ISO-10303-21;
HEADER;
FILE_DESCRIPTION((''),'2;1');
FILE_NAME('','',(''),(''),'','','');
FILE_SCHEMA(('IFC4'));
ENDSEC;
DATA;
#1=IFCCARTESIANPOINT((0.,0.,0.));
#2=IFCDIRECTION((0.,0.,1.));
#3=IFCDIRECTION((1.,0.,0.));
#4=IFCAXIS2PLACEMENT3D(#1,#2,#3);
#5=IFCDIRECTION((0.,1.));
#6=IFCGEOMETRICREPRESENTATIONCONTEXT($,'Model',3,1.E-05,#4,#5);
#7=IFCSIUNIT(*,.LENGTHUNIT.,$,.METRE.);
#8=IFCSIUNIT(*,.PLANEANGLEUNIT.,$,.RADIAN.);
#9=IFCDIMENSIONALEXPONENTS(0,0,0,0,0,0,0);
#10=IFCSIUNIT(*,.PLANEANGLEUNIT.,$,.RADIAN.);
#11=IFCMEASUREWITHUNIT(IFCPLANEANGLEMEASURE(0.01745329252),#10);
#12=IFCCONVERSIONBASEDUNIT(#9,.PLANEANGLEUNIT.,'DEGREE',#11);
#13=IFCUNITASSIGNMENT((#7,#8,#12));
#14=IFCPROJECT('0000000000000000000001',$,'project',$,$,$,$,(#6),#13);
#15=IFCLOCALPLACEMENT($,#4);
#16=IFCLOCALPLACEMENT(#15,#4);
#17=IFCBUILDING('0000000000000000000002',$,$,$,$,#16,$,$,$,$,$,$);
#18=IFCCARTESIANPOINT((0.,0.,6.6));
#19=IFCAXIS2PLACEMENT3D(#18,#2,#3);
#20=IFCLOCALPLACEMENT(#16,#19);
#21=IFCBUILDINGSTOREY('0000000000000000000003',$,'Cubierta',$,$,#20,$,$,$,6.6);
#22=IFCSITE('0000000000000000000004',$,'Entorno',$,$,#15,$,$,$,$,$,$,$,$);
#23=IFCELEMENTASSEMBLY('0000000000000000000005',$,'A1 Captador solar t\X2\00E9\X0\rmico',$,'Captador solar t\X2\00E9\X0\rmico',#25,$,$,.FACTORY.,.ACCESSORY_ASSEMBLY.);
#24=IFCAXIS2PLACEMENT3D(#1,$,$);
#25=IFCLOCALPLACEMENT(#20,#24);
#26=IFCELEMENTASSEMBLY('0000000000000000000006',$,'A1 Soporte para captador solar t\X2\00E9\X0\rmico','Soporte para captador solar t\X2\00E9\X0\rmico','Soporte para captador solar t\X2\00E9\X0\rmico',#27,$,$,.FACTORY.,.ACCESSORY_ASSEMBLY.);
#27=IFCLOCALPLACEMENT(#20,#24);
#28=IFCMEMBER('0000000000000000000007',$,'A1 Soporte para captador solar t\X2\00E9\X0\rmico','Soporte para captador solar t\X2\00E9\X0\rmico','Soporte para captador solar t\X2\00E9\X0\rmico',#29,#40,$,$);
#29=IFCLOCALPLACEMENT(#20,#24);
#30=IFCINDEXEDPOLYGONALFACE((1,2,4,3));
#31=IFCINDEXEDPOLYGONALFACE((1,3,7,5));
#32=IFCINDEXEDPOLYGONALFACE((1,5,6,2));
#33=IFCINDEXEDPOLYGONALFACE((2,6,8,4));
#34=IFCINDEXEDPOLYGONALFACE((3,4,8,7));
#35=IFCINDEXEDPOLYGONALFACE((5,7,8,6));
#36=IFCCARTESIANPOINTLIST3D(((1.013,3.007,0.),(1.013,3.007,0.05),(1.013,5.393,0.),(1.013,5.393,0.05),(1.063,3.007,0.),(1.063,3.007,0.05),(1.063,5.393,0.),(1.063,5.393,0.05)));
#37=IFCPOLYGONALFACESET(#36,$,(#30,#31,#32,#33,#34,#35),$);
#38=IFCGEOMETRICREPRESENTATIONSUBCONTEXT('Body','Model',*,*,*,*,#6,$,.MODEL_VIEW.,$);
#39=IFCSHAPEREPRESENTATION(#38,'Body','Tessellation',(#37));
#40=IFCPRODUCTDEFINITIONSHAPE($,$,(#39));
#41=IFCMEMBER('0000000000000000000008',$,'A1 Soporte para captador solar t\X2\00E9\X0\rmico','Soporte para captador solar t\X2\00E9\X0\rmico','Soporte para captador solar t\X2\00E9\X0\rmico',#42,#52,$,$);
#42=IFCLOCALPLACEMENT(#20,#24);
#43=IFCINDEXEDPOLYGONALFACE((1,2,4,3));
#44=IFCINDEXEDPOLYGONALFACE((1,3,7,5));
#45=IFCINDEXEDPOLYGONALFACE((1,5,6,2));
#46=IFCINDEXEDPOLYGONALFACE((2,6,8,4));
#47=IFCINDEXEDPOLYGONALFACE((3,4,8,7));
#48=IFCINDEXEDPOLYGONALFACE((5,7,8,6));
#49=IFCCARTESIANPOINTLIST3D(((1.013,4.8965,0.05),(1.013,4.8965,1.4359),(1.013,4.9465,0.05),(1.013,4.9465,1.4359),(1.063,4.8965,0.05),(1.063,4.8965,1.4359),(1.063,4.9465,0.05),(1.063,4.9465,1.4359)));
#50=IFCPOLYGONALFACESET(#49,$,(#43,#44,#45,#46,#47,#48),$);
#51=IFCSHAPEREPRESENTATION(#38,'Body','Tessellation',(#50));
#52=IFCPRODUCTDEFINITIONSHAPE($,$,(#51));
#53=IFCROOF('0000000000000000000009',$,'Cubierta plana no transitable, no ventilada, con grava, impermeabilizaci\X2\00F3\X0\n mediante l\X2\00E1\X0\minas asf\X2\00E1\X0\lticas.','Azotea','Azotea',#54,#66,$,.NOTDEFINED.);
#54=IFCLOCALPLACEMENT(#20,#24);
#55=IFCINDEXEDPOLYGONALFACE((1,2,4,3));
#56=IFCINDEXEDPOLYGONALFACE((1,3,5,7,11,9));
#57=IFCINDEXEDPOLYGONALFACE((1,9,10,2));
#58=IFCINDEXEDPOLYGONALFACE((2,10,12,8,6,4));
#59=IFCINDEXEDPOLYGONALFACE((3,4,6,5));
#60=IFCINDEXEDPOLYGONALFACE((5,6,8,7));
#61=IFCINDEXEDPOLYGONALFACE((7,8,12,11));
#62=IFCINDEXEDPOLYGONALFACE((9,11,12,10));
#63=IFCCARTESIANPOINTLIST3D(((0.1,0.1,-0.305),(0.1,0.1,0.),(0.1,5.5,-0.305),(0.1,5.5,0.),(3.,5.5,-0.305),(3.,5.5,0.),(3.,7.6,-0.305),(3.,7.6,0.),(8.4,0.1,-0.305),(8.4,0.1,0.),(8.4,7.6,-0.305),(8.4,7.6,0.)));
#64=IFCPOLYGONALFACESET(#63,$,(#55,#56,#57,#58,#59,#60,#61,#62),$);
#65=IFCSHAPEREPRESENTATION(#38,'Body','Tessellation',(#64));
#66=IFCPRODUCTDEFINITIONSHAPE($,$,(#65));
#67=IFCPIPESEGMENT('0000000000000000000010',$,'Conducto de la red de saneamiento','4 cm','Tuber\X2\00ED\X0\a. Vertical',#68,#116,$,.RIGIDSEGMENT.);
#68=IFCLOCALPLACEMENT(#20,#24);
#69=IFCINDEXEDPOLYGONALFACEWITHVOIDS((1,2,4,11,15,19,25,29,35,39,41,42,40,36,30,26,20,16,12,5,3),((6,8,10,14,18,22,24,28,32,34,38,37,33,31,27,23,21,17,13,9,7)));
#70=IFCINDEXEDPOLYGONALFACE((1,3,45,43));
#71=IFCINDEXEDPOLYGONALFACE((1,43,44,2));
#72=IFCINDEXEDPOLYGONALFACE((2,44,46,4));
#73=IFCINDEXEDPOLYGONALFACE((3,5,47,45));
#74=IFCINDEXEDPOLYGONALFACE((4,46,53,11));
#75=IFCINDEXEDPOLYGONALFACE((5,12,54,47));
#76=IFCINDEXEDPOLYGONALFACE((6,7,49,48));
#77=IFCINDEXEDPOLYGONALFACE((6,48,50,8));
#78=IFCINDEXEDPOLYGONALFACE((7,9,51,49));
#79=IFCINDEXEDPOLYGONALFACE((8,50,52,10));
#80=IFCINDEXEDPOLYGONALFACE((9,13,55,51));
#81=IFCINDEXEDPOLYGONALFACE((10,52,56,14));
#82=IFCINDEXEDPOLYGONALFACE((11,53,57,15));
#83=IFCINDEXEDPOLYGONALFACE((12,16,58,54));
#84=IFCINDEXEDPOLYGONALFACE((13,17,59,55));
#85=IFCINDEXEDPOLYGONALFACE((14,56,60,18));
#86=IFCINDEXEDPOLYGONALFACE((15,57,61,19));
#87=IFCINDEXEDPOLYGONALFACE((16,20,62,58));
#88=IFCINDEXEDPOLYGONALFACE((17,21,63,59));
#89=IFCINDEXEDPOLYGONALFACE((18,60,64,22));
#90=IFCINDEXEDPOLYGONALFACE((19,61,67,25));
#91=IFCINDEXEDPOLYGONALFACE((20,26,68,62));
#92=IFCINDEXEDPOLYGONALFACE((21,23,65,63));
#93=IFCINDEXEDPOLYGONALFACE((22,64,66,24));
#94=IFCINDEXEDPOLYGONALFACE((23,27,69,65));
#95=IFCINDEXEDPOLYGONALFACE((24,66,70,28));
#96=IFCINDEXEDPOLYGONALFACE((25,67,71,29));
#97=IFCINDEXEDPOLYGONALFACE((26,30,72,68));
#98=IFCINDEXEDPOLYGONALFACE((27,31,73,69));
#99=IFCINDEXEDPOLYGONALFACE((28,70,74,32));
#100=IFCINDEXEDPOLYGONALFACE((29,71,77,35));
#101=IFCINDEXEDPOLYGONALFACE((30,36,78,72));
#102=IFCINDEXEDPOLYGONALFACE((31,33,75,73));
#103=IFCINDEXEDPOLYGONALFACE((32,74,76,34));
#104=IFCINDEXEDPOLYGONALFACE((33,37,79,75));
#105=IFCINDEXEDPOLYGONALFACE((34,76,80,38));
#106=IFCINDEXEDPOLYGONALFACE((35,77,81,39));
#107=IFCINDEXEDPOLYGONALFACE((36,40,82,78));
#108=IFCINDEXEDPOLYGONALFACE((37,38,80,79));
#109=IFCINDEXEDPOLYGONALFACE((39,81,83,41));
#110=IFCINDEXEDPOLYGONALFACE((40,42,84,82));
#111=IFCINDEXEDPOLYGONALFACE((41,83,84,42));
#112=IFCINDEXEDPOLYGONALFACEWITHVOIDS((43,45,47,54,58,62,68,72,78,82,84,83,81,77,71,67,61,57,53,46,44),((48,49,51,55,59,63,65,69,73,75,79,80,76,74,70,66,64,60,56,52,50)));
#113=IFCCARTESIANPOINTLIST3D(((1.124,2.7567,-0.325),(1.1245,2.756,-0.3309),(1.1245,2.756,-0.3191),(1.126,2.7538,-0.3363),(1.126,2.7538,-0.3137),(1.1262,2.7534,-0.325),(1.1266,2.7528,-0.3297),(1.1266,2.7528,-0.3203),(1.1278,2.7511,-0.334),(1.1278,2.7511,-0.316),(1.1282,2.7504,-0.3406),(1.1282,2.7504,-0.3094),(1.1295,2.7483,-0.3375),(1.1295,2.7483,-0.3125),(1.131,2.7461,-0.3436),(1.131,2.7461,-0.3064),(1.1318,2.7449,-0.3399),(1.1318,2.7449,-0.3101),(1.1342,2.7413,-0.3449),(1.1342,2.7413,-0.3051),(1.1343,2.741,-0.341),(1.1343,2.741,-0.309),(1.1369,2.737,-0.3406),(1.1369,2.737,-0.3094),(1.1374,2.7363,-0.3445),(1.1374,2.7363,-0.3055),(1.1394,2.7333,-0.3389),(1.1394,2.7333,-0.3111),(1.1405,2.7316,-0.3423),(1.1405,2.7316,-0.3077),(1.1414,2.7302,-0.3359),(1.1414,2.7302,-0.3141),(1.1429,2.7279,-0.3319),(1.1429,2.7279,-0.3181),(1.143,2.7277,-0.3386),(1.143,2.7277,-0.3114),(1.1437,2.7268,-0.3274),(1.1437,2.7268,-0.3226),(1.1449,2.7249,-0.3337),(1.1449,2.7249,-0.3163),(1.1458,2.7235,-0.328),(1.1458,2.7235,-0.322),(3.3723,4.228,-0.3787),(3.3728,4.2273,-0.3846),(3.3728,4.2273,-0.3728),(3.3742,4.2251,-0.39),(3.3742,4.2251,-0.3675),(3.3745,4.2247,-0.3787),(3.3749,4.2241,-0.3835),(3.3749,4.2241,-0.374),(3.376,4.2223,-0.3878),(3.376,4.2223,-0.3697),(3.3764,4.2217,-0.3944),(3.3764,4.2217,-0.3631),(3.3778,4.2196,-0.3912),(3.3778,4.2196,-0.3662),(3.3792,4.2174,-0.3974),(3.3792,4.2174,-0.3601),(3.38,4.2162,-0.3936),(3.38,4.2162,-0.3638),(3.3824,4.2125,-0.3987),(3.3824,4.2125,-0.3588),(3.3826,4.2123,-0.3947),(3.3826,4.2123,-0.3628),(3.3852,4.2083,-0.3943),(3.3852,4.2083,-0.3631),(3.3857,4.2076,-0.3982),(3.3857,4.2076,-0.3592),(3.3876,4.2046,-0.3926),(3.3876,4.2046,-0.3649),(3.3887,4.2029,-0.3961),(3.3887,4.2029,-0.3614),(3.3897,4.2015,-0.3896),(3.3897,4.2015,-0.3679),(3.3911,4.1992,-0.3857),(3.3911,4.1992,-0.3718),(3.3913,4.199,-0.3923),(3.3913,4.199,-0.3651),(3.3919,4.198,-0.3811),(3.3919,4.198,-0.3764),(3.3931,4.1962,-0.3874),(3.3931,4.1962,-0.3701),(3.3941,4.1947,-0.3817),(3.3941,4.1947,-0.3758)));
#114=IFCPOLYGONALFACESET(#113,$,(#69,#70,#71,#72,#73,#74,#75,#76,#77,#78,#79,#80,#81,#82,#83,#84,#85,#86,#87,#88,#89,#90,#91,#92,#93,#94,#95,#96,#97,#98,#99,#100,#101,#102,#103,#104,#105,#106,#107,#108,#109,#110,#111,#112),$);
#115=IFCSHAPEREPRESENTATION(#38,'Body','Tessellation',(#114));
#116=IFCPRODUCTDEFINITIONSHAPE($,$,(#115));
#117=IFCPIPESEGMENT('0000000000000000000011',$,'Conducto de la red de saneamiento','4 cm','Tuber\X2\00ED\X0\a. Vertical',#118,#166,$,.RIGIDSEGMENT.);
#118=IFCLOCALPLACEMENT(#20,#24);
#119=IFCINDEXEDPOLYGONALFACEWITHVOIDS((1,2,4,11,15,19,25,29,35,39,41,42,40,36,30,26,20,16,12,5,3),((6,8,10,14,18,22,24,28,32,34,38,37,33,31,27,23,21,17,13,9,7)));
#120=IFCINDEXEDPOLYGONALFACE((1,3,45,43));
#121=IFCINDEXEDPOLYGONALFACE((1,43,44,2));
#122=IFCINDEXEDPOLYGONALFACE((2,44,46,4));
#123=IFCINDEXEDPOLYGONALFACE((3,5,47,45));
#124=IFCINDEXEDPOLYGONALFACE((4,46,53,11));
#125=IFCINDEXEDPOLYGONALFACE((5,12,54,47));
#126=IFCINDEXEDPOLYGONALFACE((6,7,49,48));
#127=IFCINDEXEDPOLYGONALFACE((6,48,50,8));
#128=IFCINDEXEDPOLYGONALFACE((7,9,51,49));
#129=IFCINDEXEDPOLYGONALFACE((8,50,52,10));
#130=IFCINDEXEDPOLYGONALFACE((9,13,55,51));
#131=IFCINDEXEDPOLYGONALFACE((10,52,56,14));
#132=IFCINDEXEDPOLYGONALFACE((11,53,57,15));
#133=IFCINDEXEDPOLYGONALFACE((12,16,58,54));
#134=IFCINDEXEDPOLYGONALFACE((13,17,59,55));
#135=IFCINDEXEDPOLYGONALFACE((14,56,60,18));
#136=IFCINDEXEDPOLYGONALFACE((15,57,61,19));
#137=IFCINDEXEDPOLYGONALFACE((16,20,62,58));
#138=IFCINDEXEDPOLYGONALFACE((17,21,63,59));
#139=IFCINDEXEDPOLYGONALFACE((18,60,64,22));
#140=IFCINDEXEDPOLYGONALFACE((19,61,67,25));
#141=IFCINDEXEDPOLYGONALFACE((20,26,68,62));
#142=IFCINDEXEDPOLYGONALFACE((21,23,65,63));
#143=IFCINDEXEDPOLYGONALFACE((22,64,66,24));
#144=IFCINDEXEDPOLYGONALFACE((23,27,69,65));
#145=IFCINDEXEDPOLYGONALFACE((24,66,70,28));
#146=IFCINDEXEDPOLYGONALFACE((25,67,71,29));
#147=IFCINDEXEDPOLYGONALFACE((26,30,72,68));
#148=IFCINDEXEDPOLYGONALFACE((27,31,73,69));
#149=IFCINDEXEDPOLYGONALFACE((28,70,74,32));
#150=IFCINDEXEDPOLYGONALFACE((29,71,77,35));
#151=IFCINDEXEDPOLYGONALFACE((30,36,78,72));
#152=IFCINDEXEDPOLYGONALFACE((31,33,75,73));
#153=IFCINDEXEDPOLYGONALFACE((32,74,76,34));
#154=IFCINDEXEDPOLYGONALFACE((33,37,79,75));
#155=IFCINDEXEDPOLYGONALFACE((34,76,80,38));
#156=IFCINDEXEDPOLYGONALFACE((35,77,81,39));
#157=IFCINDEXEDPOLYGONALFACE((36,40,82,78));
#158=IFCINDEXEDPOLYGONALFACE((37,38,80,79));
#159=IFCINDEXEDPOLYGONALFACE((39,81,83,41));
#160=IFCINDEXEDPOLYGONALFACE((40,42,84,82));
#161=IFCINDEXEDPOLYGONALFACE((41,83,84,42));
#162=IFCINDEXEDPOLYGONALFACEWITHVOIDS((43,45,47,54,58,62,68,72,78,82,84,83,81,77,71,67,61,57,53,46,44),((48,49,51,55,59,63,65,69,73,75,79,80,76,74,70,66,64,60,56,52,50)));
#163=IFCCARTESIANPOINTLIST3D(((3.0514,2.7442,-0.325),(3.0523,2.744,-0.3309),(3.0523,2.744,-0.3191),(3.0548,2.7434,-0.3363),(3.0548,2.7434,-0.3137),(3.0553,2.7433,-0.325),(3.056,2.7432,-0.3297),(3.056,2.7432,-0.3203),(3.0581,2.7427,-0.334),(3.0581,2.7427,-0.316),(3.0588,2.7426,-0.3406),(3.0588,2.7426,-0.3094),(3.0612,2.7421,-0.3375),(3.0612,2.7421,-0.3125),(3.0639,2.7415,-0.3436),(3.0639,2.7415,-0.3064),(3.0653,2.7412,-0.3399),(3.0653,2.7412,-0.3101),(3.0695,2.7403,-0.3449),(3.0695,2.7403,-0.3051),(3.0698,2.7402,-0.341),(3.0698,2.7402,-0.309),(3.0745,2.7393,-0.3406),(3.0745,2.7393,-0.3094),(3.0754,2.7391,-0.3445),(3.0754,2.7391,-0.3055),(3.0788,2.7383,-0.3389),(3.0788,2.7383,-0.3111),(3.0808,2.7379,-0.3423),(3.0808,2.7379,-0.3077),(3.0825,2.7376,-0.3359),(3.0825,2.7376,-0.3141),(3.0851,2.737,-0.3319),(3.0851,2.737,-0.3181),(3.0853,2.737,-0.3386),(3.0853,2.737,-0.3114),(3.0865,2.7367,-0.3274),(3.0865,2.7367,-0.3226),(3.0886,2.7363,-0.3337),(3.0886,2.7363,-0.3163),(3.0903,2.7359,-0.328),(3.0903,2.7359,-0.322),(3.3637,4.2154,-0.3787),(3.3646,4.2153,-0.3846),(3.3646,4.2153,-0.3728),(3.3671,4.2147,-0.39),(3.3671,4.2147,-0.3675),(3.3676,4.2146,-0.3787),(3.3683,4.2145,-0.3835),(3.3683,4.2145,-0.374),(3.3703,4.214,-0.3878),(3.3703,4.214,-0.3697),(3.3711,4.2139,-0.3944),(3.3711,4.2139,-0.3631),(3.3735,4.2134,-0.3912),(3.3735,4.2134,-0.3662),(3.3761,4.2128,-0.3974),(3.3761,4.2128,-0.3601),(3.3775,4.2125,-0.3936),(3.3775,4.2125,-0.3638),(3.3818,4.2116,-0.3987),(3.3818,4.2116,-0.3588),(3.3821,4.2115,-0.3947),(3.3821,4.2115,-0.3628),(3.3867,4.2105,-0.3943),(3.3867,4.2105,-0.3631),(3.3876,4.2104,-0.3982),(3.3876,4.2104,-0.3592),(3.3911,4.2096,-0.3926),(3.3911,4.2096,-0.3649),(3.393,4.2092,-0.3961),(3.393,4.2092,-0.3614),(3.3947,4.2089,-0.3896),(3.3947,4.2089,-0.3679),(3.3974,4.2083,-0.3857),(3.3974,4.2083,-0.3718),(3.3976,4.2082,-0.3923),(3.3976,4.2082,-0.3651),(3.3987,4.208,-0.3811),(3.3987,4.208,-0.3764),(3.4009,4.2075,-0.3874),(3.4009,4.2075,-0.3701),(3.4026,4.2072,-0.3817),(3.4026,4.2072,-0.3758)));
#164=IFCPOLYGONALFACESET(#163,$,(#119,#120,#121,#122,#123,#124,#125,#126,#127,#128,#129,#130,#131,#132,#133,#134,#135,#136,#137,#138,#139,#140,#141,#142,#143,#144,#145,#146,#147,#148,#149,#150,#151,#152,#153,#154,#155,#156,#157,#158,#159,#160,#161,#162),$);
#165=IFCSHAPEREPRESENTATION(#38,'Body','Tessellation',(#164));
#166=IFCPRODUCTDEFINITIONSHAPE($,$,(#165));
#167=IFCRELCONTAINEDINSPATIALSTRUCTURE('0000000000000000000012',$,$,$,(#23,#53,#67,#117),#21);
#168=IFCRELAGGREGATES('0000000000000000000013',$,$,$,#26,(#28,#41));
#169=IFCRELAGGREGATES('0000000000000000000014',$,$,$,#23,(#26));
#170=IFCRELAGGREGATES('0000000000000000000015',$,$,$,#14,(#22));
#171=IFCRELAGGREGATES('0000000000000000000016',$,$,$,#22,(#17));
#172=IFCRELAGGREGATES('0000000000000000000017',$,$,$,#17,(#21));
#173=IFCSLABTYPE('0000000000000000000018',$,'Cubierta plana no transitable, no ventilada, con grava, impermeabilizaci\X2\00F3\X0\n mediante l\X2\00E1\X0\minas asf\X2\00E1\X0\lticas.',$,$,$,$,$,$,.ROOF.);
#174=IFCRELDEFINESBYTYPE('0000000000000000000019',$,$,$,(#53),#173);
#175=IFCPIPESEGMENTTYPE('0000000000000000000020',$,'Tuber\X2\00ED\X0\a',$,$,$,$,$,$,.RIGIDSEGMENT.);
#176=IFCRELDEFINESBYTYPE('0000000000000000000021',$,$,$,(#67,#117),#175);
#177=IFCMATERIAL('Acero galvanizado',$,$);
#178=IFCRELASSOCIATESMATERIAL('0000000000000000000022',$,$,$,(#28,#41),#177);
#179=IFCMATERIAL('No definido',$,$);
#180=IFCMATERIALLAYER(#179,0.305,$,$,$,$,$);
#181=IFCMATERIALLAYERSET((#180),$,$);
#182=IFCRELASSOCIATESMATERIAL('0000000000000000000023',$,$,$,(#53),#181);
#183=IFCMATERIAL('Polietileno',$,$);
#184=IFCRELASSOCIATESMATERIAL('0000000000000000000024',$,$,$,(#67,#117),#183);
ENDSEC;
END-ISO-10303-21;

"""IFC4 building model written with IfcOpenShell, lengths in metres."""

from ifc_helpers import new_model, entity, si_unit, converted_unit, direction, frame, origin_with_axes, origin_2d_with_axis, place, context, subcontext, project, spatial, polyline, rectangle, hollow_circle, outline, extrude, material, layer, layer_set, layer_usage, type_object, element, aggregate, save


model = new_model("IFC4")

# Units and contexts
model_context = context("Model", 3, precision=1e-05, world=origin_with_axes(), true_north=direction((0.0, 1.0)))
body_context = subcontext(model_context, "Body", "Model", "MODEL_VIEW")
ifc_project = project(units=[si_unit("LENGTHUNIT", "METRE"), si_unit("PLANEANGLEUNIT", "RADIAN"), converted_unit("PLANEANGLEUNIT", "DEGREE", entity("IfcPlaneAngleMeasure", 0.01745329252), si_unit("PLANEANGLEUNIT", "RADIAN"), dimensions=[0, 0, 0, 0, 0, 0, 0])], contexts=[model_context])

# Site, building, storey
site_placement = place(None, origin_with_axes())
site = spatial("IfcSite", under=ifc_project, at=site_placement, Name="Entorno")
building_placement = place(site_placement, origin_with_axes())
building = spatial("IfcBuilding", under=site, at=building_placement)
storey_placement = place(building_placement, frame((0.0, 0.0, 6.6), z_axis=(0.0, 0.0, 1.0), x_axis=(1.0, 0.0, 0.0)))
storey = spatial("IfcBuildingStorey", under=building, at=storey_placement, Name="Cubierta", Elevation=6.6)

# Element assemblies, members
assembly_1_placement = place(storey_placement, frame((1.85, 4.2, 0.0), z_axis=(0.0, 0.0, 1.0), x_axis=(1.0, 0.0, 0.0)))
assembly_1 = element("IfcElementAssembly", 1, at=assembly_1_placement, inside=storey, Name="A1 Captador solar térmico", ObjectType="Captador solar térmico", AssemblyPlace="FACTORY", PredefinedType="ACCESSORY_ASSEMBLY")
assembly_2_placement = place(storey_placement, frame((1.038, 5.393, 0.025), z_axis=(0.0, -1.0, 0.0), x_axis=(1.0, 0.0, 0.0)))
assembly_2 = element("IfcElementAssembly", 2, at=assembly_2_placement, Name="A1 Soporte para captador solar térmico", Description="Soporte para captador solar térmico", ObjectType="Soporte para captador solar térmico", AssemblyPlace="FACTORY", PredefinedType="ACCESSORY_ASSEMBLY")
ifc_material_1 = material(Name="Acero galvanizado")
member_1_placement = place(assembly_2_placement, origin_with_axes())
member_1 = element("IfcMember", 3, at=member_1_placement, material=ifc_material_1, Name="A1 Soporte para captador solar térmico", Description="Soporte para captador solar térmico", ObjectType="Soporte para captador solar térmico", context=body_context, shape_type="SweptSolid", body=[
    extrude(rectangle(XDim=0.05, YDim=0.05, at=origin_2d_with_axis()), origin_with_axes(), (0.0, 0.0, 1.0), 2.3859),
])
member_2_placement = place(assembly_2_placement, frame((0.0, 0.025, 0.4715), z_axis=(0.0, 1.0, 0.0), x_axis=(1.0, 0.0, 0.0)))
member_2 = element("IfcMember", 4, at=member_2_placement, material=ifc_material_1, Name="A1 Soporte para captador solar térmico", Description="Soporte para captador solar térmico", ObjectType="Soporte para captador solar térmico", context=body_context, shape_type="SweptSolid", body=[
    extrude(rectangle(XDim=0.05, YDim=0.05, at=origin_2d_with_axis()), origin_with_axes(), (0.0, 0.0, 1.0), 1.3859),
])
aggregate(assembly_2, [member_1, member_2])

# Roof
ifc_material_2 = material(Name="No definido")
ifc_layer = layer(ifc_material_2, 0.305)
ifc_layer_set = layer_set([ifc_layer])
ifc_layer_usage = layer_usage(ifc_layer_set, "AXIS3", "POSITIVE", 0.0)
slab_type = type_object("IfcSlabType", Name="Cubierta plana no transitable, no ventilada, con grava, impermeabilización mediante láminas asfálticas.", PredefinedType="ROOF")
roof_placement = place(storey_placement, frame((3.0, 7.6, -0.305), z_axis=(0.0, 0.0, 1.0), x_axis=(1.0, 0.0, 0.0)))
element("IfcRoof", 5, at=roof_placement, inside=storey, type_object=slab_type, material=ifc_layer_usage, Name="Cubierta plana no transitable, no ventilada, con grava, impermeabilización mediante láminas asfálticas.", Description="Azotea", ObjectType="Azotea", PredefinedType="NOTDEFINED", context=body_context, shape_type="SweptSolid", body=[
    extrude(outline(polyline([(0.0, 0.0), (0.0, -2.1), (-2.9, -2.1), (-2.9, -7.5), (5.4, -7.5), (5.4, 0.0), (0.0, 0.0)])), origin_with_axes(), (0.0, 0.0, 1.0), 0.305),
])

# Pipe segments
ifc_material_3 = material(Name="Polietileno")
pipe_segment_type_1 = type_object("IfcPipeSegmentType", Name="Tubería", PredefinedType="RIGIDSEGMENT")
pipe_segment_1_placement = place(storey_placement, frame((1.135, 2.74, -0.325), z_axis=(0.836752, 0.547582, 0.0), x_axis=(-0.547582, 0.836752, 0.0)))
element("IfcPipeSegment", 6, at=pipe_segment_1_placement, inside=storey, type_object=pipe_segment_type_1, material=ifc_material_3, Name="Conducto de la red de saneamiento", Description="4 cm", ObjectType="Tubería. Vertical", PredefinedType="RIGIDSEGMENT", context=body_context, shape_type="SweptSolid", body=[
    extrude(hollow_circle(Radius=0.02, WallThickness=0.004, at=origin_2d_with_axis()), origin_with_axes(), (0.0, -0.019996, 0.9998), 2.6874),
])
pipe_segment_2_placement = place(storey_placement, frame((3.071, 2.74, -0.325), z_axis=(0.207605, 0.978213, 0.0), x_axis=(-0.978213, 0.207605, 0.0)))
element("IfcPipeSegment", 7, at=pipe_segment_2_placement, inside=storey, type_object=pipe_segment_type_1, material=ifc_material_3, Name="Conducto de la red de saneamiento", Description="4 cm", ObjectType="Tubería. Vertical", PredefinedType="RIGIDSEGMENT", context=body_context, shape_type="SweptSolid", body=[
    extrude(hollow_circle(Radius=0.02, WallThickness=0.004, at=origin_2d_with_axis()), origin_with_axes(), (0.0, -0.035706, 0.999362), 1.505),
])

aggregate(assembly_1, [assembly_2])

save(model, "model.ifc")
